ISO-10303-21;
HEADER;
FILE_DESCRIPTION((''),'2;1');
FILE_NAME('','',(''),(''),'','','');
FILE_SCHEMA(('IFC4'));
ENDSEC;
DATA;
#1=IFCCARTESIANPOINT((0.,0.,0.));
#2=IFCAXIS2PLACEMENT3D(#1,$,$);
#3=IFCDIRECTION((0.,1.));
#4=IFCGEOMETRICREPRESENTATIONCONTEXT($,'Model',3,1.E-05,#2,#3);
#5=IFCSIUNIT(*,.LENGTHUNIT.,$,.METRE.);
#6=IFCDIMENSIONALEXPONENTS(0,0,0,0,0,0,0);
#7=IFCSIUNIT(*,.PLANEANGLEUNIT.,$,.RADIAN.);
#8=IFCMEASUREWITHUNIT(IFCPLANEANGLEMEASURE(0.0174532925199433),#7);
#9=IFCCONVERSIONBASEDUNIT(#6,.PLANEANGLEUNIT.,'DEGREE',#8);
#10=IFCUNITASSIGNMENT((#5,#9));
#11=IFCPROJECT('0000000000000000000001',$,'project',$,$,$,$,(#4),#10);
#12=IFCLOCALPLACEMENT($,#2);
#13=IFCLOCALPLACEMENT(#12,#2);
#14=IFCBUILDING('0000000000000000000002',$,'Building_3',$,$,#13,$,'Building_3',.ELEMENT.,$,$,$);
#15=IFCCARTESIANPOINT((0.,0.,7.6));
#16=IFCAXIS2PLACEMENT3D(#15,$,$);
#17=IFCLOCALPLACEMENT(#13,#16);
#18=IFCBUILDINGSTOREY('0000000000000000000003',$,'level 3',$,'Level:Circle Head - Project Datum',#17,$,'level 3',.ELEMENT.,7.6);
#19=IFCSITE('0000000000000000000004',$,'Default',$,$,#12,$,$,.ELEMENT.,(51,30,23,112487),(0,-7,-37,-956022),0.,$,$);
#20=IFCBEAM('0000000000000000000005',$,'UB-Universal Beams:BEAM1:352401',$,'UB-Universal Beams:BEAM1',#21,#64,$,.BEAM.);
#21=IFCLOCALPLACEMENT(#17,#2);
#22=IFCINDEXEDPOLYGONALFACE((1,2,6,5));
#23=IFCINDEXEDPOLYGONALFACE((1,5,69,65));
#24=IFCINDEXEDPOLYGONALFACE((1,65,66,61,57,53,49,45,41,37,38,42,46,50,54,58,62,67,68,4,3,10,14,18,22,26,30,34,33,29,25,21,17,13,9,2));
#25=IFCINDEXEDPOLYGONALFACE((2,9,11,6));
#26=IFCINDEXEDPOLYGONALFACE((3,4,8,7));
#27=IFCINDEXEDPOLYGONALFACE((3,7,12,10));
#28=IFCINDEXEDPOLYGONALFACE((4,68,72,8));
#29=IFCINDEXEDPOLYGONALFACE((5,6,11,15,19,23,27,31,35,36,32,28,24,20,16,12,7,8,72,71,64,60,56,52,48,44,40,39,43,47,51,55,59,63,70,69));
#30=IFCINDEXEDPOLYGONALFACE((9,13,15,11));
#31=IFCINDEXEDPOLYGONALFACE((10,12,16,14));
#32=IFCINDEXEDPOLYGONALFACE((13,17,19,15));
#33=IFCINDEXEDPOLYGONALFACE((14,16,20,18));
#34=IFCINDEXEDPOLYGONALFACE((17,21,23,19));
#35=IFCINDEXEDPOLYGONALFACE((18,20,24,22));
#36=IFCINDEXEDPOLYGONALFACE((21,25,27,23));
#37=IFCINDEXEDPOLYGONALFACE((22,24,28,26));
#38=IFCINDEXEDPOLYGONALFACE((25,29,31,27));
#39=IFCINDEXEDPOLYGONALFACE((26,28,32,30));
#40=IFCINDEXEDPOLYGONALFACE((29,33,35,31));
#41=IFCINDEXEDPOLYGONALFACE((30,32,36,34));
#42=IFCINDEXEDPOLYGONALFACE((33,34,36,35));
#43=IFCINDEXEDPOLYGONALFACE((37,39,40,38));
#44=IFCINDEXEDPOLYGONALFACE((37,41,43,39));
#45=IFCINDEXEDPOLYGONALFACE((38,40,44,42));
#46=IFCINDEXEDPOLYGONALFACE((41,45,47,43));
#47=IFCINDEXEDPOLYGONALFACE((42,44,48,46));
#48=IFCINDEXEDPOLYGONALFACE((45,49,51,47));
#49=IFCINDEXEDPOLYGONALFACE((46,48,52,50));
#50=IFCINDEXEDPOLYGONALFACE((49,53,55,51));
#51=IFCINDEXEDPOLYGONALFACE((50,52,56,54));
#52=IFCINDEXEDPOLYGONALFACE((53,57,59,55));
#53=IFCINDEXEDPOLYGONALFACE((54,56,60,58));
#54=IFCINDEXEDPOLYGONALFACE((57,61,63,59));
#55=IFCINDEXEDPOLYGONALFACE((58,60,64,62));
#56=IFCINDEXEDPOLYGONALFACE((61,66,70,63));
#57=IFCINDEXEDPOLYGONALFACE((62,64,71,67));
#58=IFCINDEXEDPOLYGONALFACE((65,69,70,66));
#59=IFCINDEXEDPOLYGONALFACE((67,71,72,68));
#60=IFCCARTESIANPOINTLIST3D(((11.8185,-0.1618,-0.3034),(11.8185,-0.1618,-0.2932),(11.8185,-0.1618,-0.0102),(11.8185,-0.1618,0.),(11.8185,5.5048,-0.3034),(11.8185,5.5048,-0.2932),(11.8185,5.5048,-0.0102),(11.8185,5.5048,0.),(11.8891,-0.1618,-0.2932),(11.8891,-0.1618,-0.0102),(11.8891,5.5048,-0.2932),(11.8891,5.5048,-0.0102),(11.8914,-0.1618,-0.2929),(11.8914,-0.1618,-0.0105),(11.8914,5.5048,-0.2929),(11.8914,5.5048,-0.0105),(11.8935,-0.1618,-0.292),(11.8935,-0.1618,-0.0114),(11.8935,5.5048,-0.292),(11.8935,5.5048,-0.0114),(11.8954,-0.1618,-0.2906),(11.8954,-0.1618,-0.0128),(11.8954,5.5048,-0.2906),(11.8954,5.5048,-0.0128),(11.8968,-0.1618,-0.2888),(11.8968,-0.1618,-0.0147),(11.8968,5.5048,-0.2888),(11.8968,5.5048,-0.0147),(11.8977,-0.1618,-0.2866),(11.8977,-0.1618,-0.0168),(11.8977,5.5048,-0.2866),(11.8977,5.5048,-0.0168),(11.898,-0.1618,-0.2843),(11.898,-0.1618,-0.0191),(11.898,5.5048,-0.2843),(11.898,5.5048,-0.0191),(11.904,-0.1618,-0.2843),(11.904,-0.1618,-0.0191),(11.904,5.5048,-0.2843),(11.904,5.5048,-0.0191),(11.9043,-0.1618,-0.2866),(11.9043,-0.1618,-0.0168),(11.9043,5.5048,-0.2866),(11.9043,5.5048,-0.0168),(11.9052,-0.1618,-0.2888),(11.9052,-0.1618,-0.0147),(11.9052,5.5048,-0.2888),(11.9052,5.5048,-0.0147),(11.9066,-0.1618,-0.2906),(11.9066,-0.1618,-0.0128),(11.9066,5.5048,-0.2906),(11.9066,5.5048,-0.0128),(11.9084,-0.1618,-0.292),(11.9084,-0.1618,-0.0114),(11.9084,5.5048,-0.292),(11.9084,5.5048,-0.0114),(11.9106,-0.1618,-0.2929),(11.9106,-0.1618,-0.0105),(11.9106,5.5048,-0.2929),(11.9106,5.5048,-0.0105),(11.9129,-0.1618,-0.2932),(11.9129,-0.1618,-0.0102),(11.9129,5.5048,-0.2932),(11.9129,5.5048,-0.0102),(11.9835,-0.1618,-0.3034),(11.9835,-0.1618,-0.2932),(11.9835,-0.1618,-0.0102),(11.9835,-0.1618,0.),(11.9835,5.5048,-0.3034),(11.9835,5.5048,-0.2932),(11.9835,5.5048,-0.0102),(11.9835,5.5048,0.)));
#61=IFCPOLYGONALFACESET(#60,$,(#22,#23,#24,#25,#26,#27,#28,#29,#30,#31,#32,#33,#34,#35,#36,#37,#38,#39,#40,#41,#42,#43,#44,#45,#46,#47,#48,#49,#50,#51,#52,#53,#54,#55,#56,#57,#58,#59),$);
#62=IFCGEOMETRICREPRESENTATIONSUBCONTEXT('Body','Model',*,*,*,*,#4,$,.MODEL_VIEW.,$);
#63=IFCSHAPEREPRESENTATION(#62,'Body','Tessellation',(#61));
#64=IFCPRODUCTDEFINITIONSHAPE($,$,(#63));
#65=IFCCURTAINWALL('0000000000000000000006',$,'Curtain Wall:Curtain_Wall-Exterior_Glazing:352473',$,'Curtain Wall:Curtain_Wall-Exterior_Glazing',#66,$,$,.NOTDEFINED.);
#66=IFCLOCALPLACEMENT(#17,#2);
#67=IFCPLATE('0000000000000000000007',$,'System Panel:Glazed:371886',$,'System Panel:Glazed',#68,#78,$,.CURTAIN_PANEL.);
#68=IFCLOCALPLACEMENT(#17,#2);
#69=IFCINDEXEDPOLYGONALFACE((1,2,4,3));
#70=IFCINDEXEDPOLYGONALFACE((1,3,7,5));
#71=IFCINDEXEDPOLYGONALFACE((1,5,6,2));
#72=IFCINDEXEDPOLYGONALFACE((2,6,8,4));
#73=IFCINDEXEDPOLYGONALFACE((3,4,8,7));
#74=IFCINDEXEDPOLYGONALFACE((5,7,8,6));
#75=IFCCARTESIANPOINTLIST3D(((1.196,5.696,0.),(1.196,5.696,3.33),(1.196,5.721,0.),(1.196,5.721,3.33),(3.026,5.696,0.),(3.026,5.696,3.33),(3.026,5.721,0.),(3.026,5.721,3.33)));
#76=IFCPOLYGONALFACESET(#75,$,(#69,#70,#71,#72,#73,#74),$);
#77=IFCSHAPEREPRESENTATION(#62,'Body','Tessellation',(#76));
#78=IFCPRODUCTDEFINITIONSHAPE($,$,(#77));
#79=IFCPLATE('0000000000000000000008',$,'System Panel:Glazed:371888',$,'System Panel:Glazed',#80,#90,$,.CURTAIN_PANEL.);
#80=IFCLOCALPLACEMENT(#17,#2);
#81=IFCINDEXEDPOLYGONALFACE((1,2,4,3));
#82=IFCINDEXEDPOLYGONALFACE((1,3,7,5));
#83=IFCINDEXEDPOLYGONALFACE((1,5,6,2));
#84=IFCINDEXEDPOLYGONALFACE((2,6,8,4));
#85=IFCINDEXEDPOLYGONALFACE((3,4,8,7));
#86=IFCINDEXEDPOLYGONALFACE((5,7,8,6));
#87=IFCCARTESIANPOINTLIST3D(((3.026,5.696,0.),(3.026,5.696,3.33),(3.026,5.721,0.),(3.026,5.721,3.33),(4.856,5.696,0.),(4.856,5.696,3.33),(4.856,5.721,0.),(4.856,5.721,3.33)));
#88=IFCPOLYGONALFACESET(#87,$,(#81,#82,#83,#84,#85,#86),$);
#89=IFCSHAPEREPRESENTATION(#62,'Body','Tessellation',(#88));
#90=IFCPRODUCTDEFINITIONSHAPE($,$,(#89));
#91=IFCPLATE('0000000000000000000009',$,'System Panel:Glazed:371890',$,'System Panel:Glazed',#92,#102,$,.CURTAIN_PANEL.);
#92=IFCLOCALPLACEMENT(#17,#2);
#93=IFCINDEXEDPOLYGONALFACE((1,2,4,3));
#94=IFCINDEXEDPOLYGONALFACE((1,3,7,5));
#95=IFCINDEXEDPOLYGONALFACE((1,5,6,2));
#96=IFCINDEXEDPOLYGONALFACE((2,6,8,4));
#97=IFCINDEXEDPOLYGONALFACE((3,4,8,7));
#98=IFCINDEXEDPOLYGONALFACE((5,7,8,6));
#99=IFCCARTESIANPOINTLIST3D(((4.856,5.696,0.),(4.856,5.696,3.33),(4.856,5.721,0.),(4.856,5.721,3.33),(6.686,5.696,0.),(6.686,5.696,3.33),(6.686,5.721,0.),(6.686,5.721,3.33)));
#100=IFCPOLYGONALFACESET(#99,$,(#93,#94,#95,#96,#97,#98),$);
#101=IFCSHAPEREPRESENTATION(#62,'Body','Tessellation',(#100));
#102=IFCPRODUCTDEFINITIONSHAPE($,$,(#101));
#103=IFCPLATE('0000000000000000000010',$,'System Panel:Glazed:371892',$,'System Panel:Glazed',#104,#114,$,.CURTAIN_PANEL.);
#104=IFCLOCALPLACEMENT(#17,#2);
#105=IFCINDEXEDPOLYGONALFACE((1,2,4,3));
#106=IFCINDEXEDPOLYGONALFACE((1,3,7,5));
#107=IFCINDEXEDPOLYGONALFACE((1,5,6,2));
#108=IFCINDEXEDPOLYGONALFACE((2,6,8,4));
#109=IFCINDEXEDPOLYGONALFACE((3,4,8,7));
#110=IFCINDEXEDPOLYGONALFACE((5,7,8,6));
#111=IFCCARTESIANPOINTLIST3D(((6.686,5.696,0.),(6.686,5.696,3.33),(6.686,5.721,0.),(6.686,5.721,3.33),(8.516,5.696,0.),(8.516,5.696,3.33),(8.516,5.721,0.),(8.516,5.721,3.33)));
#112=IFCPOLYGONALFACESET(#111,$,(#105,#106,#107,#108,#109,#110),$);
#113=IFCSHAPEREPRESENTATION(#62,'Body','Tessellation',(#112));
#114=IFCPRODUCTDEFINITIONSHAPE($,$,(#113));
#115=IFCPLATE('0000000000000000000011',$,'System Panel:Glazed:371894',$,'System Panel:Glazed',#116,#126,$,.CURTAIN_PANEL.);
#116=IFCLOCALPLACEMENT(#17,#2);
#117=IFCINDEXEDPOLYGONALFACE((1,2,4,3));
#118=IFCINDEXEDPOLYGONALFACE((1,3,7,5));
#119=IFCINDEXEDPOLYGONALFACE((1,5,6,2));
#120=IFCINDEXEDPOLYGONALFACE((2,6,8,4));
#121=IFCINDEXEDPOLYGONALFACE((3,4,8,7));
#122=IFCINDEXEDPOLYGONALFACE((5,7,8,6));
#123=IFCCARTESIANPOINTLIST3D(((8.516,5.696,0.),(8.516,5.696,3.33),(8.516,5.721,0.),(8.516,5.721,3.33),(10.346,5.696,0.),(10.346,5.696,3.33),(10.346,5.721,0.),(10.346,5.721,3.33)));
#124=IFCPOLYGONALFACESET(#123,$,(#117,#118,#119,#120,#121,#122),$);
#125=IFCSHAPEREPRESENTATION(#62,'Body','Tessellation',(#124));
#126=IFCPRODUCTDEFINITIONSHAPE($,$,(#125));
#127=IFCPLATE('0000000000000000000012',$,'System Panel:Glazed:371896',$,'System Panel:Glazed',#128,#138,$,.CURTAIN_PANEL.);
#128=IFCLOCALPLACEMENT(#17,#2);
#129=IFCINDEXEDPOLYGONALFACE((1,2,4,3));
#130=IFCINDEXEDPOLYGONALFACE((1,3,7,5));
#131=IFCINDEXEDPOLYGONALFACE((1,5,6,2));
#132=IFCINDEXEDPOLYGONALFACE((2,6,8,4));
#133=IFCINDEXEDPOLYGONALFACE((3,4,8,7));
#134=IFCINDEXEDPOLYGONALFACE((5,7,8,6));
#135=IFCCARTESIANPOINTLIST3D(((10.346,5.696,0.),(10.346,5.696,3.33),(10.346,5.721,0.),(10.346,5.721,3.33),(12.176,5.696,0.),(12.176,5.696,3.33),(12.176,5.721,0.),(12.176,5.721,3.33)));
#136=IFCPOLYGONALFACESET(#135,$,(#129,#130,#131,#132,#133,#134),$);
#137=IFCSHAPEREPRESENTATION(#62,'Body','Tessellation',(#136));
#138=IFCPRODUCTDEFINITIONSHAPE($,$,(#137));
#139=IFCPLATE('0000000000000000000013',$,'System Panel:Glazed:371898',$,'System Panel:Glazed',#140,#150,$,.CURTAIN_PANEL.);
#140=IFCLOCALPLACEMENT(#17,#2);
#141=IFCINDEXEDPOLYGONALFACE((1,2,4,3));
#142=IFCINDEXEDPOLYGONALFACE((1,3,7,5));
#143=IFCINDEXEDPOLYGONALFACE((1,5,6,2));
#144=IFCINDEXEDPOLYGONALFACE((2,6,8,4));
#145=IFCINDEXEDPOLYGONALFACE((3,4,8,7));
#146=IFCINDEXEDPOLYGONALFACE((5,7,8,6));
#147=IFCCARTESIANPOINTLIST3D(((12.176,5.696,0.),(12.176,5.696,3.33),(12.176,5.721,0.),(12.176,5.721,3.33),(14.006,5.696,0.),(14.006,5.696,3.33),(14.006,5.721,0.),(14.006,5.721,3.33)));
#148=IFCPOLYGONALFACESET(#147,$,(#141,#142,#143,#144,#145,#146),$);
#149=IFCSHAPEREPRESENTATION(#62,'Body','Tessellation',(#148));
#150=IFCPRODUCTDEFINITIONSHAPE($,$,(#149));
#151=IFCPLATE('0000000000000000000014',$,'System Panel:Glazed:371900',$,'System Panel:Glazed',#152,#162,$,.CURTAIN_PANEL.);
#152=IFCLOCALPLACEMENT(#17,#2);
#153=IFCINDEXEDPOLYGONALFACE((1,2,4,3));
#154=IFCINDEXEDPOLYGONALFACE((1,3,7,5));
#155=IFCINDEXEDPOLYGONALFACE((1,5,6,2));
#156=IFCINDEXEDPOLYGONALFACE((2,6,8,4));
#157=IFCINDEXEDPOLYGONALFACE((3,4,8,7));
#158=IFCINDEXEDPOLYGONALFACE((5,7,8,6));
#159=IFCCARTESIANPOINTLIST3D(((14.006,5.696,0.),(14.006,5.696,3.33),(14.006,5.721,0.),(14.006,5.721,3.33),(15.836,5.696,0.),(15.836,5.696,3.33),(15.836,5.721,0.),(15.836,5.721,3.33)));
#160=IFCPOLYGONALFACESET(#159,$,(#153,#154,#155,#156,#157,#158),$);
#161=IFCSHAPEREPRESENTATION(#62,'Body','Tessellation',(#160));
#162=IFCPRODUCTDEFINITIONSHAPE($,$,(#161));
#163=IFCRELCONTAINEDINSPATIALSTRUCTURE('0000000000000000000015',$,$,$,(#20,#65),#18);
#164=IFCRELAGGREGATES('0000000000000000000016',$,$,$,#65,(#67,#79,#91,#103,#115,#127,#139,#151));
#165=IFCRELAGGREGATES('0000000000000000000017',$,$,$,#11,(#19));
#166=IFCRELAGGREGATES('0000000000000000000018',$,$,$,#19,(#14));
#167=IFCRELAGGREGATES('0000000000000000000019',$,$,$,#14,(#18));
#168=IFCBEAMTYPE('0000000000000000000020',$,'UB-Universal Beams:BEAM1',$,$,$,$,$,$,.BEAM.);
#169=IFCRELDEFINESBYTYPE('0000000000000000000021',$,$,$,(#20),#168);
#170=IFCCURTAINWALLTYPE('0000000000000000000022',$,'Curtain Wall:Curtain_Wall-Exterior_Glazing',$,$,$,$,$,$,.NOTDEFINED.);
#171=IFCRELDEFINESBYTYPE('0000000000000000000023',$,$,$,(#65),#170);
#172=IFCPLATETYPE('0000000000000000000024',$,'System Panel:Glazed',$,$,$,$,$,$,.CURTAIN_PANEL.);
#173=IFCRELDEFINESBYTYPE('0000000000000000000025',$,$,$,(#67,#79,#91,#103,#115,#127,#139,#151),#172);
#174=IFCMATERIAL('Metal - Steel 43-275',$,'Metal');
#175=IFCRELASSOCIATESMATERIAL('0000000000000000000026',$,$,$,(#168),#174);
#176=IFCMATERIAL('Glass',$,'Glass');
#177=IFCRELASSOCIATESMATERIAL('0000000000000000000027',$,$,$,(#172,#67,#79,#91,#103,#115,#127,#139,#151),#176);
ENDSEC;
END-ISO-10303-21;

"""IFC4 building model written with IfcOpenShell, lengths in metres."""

from ifc_helpers import new_model, entity, si_unit, converted_unit, direction, frame, frame_2d, origin, origin_2d_with_axis, place, context, subcontext, project, spatial, polyline, circle_curve, parameter, trimmed, segment, composite_curve, rectangle, outline, extrude, source, transform, mapped, material, material_profile, profile_set, type_object, type_shapes, element, aggregate, save


model = new_model("IFC4")

# Units and contexts
model_context = context("Model", 3, precision=1e-05, world=origin(), true_north=direction((0.0, 1.0)))
body_context = subcontext(model_context, "Body", "Model", "MODEL_VIEW")
ifc_project = project(units=[si_unit("LENGTHUNIT", "METRE"), converted_unit("PLANEANGLEUNIT", "DEGREE", entity("IfcPlaneAngleMeasure", 0.0174532925199433), si_unit("PLANEANGLEUNIT", "RADIAN"), dimensions=[0, 0, 0, 0, 0, 0, 0])], contexts=[model_context])

# Site, building, storey
site_placement = place(None, origin())
site = spatial("IfcSite", under=ifc_project, at=site_placement, Name="Default", CompositionType="ELEMENT", RefLatitude=(51, 30, 23, 112487), RefLongitude=(0, -7, -37, -956022), RefElevation=0.0)
building_placement = place(site_placement, origin())
building = spatial("IfcBuilding", under=site, at=building_placement, Name="Building_3", LongName="Building_3", CompositionType="ELEMENT")
storey_placement = place(building_placement, frame((0.0, 0.0, 7.6)))
storey = spatial("IfcBuildingStorey", under=building, at=storey_placement, Name="level 3", ObjectType="Level:Circle Head - Project Datum", LongName="level 3", CompositionType="ELEMENT", Elevation=7.6)

# Shared definitions
ifc_material_1 = material(Name="Metal - Steel 43-275", Category="Metal")

# Beam
ifc_material_profile_1 = material_profile(ifc_material_1, outline(composite_curve([segment(polyline([(-0.0825, -0.1415), (-0.0825, -0.1517)]), True, "CONTINUOUS"), segment(polyline([(-0.0825, -0.1517), (0.0825, -0.1517)]), True, "CONTINUOUS"), segment(polyline([(0.0825, -0.1517), (0.0825, -0.1415)]), True, "CONTINUOUS"), segment(polyline([(0.0825, -0.1415), (0.0119, -0.1415)]), True, "CONTINUOUS"), segment(trimmed(circle_curve(frame_2d((0.0119, -0.1326), x_axis=(1.0, 0.0)), 0.0089), [parameter(180.0)], [parameter(270.0)], True, "PARAMETER"), False, "CONTINUOUS"), segment(polyline([(0.003, -0.1326), (0.003, 0.1326)]), True, "CONTINUOUS"), segment(trimmed(circle_curve(frame_2d((0.0119, 0.1326), x_axis=(1.0, 0.0)), 0.0089), [parameter(90.0)], [parameter(180.0)], True, "PARAMETER"), False, "CONTINUOUS"), segment(polyline([(0.0119, 0.1415), (0.0825, 0.1415)]), True, "CONTINUOUS"), segment(polyline([(0.0825, 0.1415), (0.0825, 0.1517)]), True, "CONTINUOUS"), segment(polyline([(0.0825, 0.1517), (-0.0825, 0.1517)]), True, "CONTINUOUS"), segment(polyline([(-0.0825, 0.1517), (-0.0825, 0.1415)]), True, "CONTINUOUS"), segment(polyline([(-0.0825, 0.1415), (-0.0119, 0.1415)]), True, "CONTINUOUS"), segment(trimmed(circle_curve(frame_2d((-0.0119, 0.1326), x_axis=(1.0, 0.0)), 0.0089), [parameter(360.0)], [parameter(90.0)], True, "PARAMETER"), False, "CONTINUOUS"), segment(polyline([(-0.003, 0.1326), (-0.003, -0.1326)]), True, "CONTINUOUS"), segment(trimmed(circle_curve(frame_2d((-0.0119, -0.1326), x_axis=(1.0, 0.0)), 0.0089), [parameter(270.0)], [parameter(360.0)], True, "PARAMETER"), False, "CONTINUOUS"), segment(polyline([(-0.0119, -0.1415), (-0.0825, -0.1415)]), True, "CONTINUOUS")], self_intersect=False)), Name="BEAM1")
ifc_profile_set_1 = profile_set([ifc_material_profile_1], Name="BEAM1")
beam_type_1 = type_object("IfcBeamType", Name="UB-Universal Beams:BEAM1", PredefinedType="BEAM", material=ifc_profile_set_1)
shared_shape_1 = source(origin(), body_context, "Body", "SweptSolid", [
    extrude(outline(composite_curve([segment(polyline([(-0.0825, -0.1415), (-0.0825, -0.1517)]), True, "CONTINUOUS"), segment(polyline([(-0.0825, -0.1517), (0.0825, -0.1517)]), True, "CONTINUOUS"), segment(polyline([(0.0825, -0.1517), (0.0825, -0.1415)]), True, "CONTINUOUS"), segment(polyline([(0.0825, -0.1415), (0.0119, -0.1415)]), True, "CONTINUOUS"), segment(trimmed(circle_curve(frame_2d((0.0119, -0.1326), x_axis=(1.0, 0.0)), 0.0089), [parameter(180.0)], [parameter(270.0)], True, "PARAMETER"), False, "CONTINUOUS"), segment(polyline([(0.003, -0.1326), (0.003, 0.1326)]), True, "CONTINUOUS"), segment(trimmed(circle_curve(frame_2d((0.0119, 0.1326), x_axis=(1.0, 0.0)), 0.0089), [parameter(90.0)], [parameter(180.0)], True, "PARAMETER"), False, "CONTINUOUS"), segment(polyline([(0.0119, 0.1415), (0.0825, 0.1415)]), True, "CONTINUOUS"), segment(polyline([(0.0825, 0.1415), (0.0825, 0.1517)]), True, "CONTINUOUS"), segment(polyline([(0.0825, 0.1517), (-0.0825, 0.1517)]), True, "CONTINUOUS"), segment(polyline([(-0.0825, 0.1517), (-0.0825, 0.1415)]), True, "CONTINUOUS"), segment(polyline([(-0.0825, 0.1415), (-0.0119, 0.1415)]), True, "CONTINUOUS"), segment(trimmed(circle_curve(frame_2d((-0.0119, 0.1326), x_axis=(1.0, 0.0)), 0.0089), [parameter(360.0)], [parameter(90.0)], True, "PARAMETER"), False, "CONTINUOUS"), segment(polyline([(-0.003, 0.1326), (-0.003, -0.1326)]), True, "CONTINUOUS"), segment(trimmed(circle_curve(frame_2d((-0.0119, -0.1326), x_axis=(1.0, 0.0)), 0.0089), [parameter(270.0)], [parameter(360.0)], True, "PARAMETER"), False, "CONTINUOUS"), segment(polyline([(-0.0119, -0.1415), (-0.0825, -0.1415)]), True, "CONTINUOUS")], self_intersect=False)), frame((-2.8333, 0.0, 0.0), z_axis=(-1.0, 0.0, 0.0), x_axis=(0.0, -1.0, 0.0)), (0.0, 0.0, -1.0), 5.6666),
])
type_shapes(beam_type_1, [shared_shape_1])
for number, where, z_axis, x_axis, name in (
    (1, (11.901, 2.6715, -0.1517), (0.0, 0.0, 1.0), (0.0, -1.0, 0.0), "UB-Universal Beams:BEAM1:352401"),
):
    element("IfcBeam", number, at=place(storey_placement, frame(where, z_axis=z_axis, x_axis=x_axis)), inside=storey, type_object=beam_type_1, Name=name, ObjectType="UB-Universal Beams:BEAM1", PredefinedType="BEAM", context=body_context, shape_type="MappedRepresentation", body=[
        mapped(shared_shape_1, transform((0.0, 0.0, 0.0), scale=1.0)),
    ])

# Curtain wall, plates
curtain_wall_type = type_object("IfcCurtainWallType", Name="Curtain Wall:Curtain_Wall-Exterior_Glazing", PredefinedType="NOTDEFINED")
curtain_wall_1_placement = place(storey_placement, frame((0.0, 0.0, -7.6)))
curtain_wall_1 = element("IfcCurtainWall", 2, at=curtain_wall_1_placement, inside=storey, type_object=curtain_wall_type, Name="Curtain Wall:Curtain_Wall-Exterior_Glazing:352473", ObjectType="Curtain Wall:Curtain_Wall-Exterior_Glazing", PredefinedType="NOTDEFINED")
ifc_material_2 = material(Name="Glass", Category="Glass")
plate_type = type_object("IfcPlateType", Name="System Panel:Glazed", PredefinedType="CURTAIN_PANEL", material=ifc_material_2)
shared_shape_2 = source(origin(), body_context, "Body", "SweptSolid", [
    extrude(rectangle(XDim=0.025, YDim=1.83, at=origin_2d_with_axis()), frame((0.915, 0.0125, 0.0), z_axis=(0.0, 0.0, 1.0), x_axis=(0.0, 1.0, 0.0)), (0.0, 0.0, 1.0), 3.33),
])
type_shapes(plate_type, [shared_shape_2])
plate_1_placement = place(curtain_wall_1_placement, frame((1.196, 5.696, 7.6)))
plate_1 = element("IfcPlate", 3, at=plate_1_placement, type_object=plate_type, material=ifc_material_2, Name="System Panel:Glazed:371886", ObjectType="System Panel:Glazed", PredefinedType="CURTAIN_PANEL", context=body_context, shape_type="MappedRepresentation", body=[
    mapped(shared_shape_2, transform((0.0, 0.0, 0.0), scale=1.0)),
])
plate_2_placement = place(curtain_wall_1_placement, frame((3.026, 5.696, 7.6)))
plate_2 = element("IfcPlate", 4, at=plate_2_placement, type_object=plate_type, material=ifc_material_2, Name="System Panel:Glazed:371888", ObjectType="System Panel:Glazed", PredefinedType="CURTAIN_PANEL", context=body_context, shape_type="MappedRepresentation", body=[
    mapped(shared_shape_2, transform((0.0, 0.0, 0.0), scale=1.0)),
])
plate_3_placement = place(curtain_wall_1_placement, frame((4.856, 5.696, 7.6)))
plate_3 = element("IfcPlate", 5, at=plate_3_placement, type_object=plate_type, material=ifc_material_2, Name="System Panel:Glazed:371890", ObjectType="System Panel:Glazed", PredefinedType="CURTAIN_PANEL", context=body_context, shape_type="MappedRepresentation", body=[
    mapped(shared_shape_2, transform((0.0, 0.0, 0.0), scale=1.0)),
])
plate_4_placement = place(curtain_wall_1_placement, frame((6.686, 5.696, 7.6)))
plate_4 = element("IfcPlate", 6, at=plate_4_placement, type_object=plate_type, material=ifc_material_2, Name="System Panel:Glazed:371892", ObjectType="System Panel:Glazed", PredefinedType="CURTAIN_PANEL", context=body_context, shape_type="MappedRepresentation", body=[
    mapped(shared_shape_2, transform((0.0, 0.0, 0.0), scale=1.0)),
])
plate_5_placement = place(curtain_wall_1_placement, frame((8.516, 5.696, 7.6)))
plate_5 = element("IfcPlate", 7, at=plate_5_placement, type_object=plate_type, material=ifc_material_2, Name="System Panel:Glazed:371894", ObjectType="System Panel:Glazed", PredefinedType="CURTAIN_PANEL", context=body_context, shape_type="MappedRepresentation", body=[
    mapped(shared_shape_2, transform((0.0, 0.0, 0.0), scale=1.0)),
])
plate_6_placement = place(curtain_wall_1_placement, frame((10.346, 5.696, 7.6)))
plate_6 = element("IfcPlate", 8, at=plate_6_placement, type_object=plate_type, material=ifc_material_2, Name="System Panel:Glazed:371896", ObjectType="System Panel:Glazed", PredefinedType="CURTAIN_PANEL", context=body_context, shape_type="MappedRepresentation", body=[
    mapped(shared_shape_2, transform((0.0, 0.0, 0.0), scale=1.0)),
])
plate_7_placement = place(curtain_wall_1_placement, frame((12.176, 5.696, 7.6)))
plate_7 = element("IfcPlate", 9, at=plate_7_placement, type_object=plate_type, material=ifc_material_2, Name="System Panel:Glazed:371898", ObjectType="System Panel:Glazed", PredefinedType="CURTAIN_PANEL", context=body_context, shape_type="MappedRepresentation", body=[
    mapped(shared_shape_2, transform((0.0, 0.0, 0.0), scale=1.0)),
])
plate_8_placement = place(curtain_wall_1_placement, frame((14.006, 5.696, 7.6)))
plate_8 = element("IfcPlate", 10, at=plate_8_placement, type_object=plate_type, material=ifc_material_2, Name="System Panel:Glazed:371900", ObjectType="System Panel:Glazed", PredefinedType="CURTAIN_PANEL", context=body_context, shape_type="MappedRepresentation", body=[
    mapped(shared_shape_2, transform((0.0, 0.0, 0.0), scale=1.0)),
])
aggregate(curtain_wall_1, [plate_1, plate_2, plate_3, plate_4, plate_5, plate_6, plate_7, plate_8])

save(model, "model.ifc")
